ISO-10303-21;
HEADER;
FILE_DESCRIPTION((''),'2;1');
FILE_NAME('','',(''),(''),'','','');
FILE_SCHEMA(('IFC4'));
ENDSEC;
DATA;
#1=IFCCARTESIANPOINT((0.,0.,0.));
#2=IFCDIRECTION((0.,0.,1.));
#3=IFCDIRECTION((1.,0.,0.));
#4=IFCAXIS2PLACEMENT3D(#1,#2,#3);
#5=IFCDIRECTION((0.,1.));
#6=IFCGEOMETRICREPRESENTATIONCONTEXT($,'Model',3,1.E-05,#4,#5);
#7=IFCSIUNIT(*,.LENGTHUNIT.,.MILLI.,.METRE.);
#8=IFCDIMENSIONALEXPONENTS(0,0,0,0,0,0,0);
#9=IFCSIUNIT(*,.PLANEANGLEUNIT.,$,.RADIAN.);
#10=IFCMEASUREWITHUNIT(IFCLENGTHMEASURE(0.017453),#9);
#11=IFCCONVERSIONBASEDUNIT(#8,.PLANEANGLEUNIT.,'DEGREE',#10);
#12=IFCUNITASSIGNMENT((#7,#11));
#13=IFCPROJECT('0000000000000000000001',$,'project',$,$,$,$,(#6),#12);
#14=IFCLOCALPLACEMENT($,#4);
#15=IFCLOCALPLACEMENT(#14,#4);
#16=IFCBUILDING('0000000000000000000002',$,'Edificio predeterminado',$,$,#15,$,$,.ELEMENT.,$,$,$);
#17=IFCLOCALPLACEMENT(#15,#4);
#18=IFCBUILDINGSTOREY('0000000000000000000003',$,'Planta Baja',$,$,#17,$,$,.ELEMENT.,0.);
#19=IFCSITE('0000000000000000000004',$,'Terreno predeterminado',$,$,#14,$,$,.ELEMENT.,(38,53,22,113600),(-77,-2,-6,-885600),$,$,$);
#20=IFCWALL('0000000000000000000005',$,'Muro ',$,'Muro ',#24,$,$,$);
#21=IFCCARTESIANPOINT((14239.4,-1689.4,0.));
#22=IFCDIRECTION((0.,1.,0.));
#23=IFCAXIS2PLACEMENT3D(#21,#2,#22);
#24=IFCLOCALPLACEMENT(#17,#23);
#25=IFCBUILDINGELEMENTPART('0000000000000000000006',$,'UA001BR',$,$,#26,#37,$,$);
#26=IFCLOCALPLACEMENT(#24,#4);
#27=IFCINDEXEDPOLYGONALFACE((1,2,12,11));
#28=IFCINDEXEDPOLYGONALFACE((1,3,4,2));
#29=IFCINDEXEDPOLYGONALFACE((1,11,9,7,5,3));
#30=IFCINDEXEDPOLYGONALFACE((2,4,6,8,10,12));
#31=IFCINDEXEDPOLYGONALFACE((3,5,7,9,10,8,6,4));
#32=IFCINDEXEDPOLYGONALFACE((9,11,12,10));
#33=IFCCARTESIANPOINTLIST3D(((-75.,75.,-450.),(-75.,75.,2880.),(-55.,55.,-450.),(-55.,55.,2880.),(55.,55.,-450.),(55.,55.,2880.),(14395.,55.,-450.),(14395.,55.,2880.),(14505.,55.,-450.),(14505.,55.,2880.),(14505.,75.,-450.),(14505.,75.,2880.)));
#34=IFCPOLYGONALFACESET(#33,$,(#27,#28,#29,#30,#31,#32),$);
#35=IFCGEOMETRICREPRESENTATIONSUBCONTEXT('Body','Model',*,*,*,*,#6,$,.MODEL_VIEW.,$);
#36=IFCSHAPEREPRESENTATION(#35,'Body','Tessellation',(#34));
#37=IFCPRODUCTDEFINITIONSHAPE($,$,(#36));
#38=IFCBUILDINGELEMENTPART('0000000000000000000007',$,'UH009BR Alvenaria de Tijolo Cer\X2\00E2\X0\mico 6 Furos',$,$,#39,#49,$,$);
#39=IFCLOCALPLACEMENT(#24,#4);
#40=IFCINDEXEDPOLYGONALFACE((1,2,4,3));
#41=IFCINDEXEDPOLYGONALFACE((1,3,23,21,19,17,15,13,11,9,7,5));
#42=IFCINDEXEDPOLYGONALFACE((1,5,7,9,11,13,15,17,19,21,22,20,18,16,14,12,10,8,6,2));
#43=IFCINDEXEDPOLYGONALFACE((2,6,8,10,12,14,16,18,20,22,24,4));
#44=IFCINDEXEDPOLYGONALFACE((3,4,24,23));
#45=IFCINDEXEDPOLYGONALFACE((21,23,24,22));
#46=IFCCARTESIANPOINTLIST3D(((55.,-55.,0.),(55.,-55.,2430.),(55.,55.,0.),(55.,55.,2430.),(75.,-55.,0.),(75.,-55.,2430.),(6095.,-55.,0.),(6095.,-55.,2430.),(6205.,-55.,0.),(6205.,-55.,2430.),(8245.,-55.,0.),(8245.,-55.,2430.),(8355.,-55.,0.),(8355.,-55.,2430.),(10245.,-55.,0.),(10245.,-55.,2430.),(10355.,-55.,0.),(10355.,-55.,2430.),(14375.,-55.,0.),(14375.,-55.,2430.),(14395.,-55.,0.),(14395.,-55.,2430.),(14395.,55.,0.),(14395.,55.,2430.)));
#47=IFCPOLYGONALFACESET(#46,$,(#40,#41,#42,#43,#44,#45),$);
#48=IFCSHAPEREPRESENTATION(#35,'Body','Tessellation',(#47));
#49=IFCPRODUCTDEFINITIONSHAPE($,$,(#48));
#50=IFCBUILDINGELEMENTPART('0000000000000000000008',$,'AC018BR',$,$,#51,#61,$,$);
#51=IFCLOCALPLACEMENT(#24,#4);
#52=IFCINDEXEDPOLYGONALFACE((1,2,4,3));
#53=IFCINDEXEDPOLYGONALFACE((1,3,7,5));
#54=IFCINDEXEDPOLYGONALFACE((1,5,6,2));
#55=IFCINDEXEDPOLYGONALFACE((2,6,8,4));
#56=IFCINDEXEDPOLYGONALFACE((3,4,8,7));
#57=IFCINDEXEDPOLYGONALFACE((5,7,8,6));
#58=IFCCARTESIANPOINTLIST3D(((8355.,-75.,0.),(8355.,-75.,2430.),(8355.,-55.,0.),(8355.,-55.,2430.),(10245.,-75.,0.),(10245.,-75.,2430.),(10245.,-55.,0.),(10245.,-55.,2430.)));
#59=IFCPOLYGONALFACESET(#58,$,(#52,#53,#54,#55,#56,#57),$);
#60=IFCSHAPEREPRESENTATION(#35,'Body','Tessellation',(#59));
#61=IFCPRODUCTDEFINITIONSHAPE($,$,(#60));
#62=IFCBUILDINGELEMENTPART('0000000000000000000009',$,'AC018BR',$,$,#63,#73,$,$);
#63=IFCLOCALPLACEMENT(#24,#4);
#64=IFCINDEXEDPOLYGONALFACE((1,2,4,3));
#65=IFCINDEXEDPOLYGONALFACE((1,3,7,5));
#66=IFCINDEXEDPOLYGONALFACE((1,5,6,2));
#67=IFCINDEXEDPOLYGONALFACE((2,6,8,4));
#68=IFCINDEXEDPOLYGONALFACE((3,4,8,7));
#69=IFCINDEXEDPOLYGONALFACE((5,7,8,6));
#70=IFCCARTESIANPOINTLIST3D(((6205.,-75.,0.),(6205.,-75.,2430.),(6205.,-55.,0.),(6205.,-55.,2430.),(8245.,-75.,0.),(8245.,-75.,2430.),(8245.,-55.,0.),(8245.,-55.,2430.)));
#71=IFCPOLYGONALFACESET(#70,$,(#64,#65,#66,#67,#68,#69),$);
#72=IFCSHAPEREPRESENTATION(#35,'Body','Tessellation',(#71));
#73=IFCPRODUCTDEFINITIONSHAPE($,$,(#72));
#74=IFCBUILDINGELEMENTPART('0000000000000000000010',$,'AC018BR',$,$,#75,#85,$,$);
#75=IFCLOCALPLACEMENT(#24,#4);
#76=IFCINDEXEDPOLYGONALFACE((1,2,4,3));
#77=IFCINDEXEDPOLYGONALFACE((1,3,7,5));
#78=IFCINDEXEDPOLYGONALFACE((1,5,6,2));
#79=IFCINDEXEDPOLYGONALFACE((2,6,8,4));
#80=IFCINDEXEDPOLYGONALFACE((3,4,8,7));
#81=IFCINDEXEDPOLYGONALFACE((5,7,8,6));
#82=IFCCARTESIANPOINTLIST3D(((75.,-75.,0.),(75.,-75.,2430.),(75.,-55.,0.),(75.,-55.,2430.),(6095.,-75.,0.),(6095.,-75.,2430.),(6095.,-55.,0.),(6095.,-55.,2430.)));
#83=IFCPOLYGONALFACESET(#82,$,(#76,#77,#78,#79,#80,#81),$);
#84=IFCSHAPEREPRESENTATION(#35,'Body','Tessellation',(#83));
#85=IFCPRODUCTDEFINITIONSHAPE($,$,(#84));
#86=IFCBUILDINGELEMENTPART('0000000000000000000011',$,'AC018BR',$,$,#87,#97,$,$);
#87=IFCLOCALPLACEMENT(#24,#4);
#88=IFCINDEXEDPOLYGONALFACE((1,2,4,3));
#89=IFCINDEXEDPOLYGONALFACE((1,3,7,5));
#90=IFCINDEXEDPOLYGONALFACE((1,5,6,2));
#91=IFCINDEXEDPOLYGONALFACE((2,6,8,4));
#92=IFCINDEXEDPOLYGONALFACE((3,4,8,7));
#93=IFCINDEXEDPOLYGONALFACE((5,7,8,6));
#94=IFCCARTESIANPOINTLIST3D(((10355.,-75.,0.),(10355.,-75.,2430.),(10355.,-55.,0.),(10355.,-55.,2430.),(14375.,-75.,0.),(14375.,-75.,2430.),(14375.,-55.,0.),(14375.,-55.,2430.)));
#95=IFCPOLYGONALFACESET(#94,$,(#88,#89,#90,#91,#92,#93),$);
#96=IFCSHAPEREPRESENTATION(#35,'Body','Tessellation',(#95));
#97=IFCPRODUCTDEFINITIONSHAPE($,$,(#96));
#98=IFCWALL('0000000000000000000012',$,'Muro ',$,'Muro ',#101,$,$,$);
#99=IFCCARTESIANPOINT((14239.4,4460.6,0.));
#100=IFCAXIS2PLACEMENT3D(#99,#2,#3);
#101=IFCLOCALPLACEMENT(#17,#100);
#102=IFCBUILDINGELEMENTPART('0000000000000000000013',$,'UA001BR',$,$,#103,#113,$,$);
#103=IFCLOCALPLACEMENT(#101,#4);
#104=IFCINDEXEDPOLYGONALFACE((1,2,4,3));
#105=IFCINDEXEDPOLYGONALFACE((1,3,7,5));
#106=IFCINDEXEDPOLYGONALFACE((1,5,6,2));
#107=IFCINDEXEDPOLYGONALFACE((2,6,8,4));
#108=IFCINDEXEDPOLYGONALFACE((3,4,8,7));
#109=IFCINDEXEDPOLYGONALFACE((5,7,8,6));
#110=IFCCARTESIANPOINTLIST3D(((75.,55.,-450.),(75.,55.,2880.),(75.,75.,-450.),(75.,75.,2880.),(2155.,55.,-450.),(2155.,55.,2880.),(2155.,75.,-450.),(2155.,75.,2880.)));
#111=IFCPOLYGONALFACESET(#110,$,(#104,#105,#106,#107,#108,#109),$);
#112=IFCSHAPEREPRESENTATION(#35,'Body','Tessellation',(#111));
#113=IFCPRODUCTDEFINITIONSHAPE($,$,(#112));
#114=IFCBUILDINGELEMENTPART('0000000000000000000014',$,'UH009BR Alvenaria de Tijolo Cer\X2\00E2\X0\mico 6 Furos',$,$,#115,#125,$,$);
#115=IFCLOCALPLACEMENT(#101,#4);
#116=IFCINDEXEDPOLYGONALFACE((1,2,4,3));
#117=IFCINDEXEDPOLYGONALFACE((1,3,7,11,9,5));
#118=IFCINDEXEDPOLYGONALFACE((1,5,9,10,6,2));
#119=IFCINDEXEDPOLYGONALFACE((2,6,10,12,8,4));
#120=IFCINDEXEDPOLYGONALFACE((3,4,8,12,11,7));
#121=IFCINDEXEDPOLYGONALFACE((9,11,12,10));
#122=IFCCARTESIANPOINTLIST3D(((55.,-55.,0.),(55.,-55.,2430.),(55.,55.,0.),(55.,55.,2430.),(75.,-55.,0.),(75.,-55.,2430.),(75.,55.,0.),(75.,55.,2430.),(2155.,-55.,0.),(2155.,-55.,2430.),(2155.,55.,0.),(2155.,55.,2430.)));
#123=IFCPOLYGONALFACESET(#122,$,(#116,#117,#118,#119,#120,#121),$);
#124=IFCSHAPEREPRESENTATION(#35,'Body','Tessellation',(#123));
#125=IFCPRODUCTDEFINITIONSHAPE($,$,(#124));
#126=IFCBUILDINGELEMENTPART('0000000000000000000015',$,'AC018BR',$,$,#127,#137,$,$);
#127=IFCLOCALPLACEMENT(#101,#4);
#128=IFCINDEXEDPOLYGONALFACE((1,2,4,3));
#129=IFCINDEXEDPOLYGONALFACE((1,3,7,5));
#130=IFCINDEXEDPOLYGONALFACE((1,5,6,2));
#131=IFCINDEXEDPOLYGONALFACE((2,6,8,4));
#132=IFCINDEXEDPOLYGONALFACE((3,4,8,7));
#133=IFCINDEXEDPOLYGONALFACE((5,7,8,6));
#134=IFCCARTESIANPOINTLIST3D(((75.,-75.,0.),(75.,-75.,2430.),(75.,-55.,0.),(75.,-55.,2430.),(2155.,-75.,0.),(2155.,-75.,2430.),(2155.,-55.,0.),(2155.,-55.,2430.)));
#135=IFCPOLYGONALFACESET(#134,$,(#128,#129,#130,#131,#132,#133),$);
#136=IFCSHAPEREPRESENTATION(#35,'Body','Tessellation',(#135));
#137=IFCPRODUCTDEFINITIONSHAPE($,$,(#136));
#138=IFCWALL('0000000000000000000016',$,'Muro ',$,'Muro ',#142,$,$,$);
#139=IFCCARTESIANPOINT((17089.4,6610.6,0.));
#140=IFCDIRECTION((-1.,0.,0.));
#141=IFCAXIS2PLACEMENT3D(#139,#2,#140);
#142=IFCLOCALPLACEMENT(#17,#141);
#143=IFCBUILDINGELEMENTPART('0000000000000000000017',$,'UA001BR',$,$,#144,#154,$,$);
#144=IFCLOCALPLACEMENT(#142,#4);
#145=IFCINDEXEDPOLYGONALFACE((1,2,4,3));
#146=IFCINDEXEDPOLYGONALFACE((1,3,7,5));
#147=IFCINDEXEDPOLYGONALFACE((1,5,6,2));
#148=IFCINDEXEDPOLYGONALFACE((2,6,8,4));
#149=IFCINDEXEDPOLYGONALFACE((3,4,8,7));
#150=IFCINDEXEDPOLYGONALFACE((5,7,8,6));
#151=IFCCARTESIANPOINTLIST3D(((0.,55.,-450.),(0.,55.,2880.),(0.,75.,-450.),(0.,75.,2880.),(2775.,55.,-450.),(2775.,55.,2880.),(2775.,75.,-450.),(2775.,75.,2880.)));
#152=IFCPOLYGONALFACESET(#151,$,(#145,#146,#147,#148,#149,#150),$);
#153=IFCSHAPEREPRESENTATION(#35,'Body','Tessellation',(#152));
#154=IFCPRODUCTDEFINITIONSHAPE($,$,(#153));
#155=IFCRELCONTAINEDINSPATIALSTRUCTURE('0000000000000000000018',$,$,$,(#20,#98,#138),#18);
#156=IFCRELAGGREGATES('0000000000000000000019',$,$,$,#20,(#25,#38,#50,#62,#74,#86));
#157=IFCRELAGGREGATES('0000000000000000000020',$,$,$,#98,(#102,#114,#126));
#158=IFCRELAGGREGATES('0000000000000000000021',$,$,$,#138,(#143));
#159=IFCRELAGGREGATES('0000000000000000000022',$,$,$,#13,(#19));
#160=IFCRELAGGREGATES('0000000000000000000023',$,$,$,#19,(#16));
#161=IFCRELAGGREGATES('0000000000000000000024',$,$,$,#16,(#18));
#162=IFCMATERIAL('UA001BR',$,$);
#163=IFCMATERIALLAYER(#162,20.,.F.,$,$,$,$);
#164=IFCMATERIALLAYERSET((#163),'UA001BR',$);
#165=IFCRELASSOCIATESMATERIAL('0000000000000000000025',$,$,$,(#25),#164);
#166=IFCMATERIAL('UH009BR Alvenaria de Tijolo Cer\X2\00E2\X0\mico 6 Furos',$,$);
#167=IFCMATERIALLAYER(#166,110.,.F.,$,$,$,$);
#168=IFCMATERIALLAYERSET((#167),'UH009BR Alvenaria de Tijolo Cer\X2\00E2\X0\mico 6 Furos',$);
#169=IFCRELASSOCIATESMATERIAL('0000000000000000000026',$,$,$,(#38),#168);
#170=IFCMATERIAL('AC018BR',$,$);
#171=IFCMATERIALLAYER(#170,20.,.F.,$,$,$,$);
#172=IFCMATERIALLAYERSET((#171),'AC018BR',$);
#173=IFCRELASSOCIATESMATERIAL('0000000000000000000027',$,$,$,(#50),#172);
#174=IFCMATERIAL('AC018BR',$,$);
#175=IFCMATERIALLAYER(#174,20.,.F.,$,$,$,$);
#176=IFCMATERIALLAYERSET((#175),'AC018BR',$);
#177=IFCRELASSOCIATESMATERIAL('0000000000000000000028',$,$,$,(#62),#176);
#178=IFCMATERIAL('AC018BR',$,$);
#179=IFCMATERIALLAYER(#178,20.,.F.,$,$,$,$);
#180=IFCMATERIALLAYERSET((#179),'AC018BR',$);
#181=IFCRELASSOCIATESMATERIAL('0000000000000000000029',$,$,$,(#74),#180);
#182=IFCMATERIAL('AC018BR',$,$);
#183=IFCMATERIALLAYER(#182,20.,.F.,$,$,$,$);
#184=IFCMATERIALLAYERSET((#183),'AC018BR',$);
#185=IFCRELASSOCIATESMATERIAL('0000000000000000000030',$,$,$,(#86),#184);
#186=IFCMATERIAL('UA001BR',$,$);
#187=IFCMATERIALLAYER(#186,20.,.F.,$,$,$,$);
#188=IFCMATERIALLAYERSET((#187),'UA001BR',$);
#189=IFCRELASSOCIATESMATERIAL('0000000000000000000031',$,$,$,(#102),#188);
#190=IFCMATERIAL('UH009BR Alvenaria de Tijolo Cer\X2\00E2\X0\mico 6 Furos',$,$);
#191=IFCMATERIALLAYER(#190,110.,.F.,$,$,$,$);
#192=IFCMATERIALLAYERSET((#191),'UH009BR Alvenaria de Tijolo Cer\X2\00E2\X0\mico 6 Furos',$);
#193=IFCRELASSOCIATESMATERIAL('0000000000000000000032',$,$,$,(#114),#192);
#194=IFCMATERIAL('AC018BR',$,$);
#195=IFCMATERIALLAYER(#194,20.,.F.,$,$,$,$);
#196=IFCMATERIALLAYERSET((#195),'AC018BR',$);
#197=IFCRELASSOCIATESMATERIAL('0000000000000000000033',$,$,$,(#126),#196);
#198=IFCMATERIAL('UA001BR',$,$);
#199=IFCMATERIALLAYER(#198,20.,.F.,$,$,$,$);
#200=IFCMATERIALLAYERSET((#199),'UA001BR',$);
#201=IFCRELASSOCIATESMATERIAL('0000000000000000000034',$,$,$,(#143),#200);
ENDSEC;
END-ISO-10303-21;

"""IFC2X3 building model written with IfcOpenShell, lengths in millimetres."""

from ifc_helpers import new_model, entity, si_unit, converted_unit, direction, frame, origin_with_axes, place, context, subcontext, project, spatial, polyline, outline, extrude, material, layer, layer_set, layer_usage, element, aggregate, save


model = new_model("IFC2X3")

# Units and contexts
model_context = context("Model", 3, precision=1e-05, world=origin_with_axes(), true_north=direction((0.0, 1.0)))
body_context = subcontext(model_context, "Body", "Model", "MODEL_VIEW")
ifc_project = project(units=[si_unit("LENGTHUNIT", "METRE", prefix="MILLI"), converted_unit("PLANEANGLEUNIT", "DEGREE", entity("IfcLengthMeasure", 0.017453), si_unit("PLANEANGLEUNIT", "RADIAN"), dimensions=[0, 0, 0, 0, 0, 0, 0])], contexts=[model_context])

# Site, building, storey
site_placement = place(None, origin_with_axes())
site = spatial("IfcSite", under=ifc_project, at=site_placement, Name="Terreno predeterminado", CompositionType="ELEMENT", RefLatitude=(38, 53, 22, 113600), RefLongitude=(-77, -2, -6, -885600))
building_placement = place(site_placement, origin_with_axes())
building = spatial("IfcBuilding", under=site, at=building_placement, Name="Edificio predeterminado", CompositionType="ELEMENT")
storey_placement = place(building_placement, origin_with_axes())
storey = spatial("IfcBuildingStorey", under=building, at=storey_placement, Name="Planta Baja", CompositionType="ELEMENT", Elevation=0.0)

# Walls, building element parts
wall_1_placement = place(storey_placement, frame((14239.4, -1689.4, 0.0), z_axis=(0.0, 0.0, 1.0), x_axis=(0.0, 1.0, 0.0)))
wall_1 = element("IfcWall", 1, at=wall_1_placement, inside=storey, Name="Muro ", ObjectType="Muro ")
ifc_material_1 = material(Name="UA001BR")
ifc_layer_1 = layer(ifc_material_1, 20.0, ventilated=False)
ifc_layer_set_1 = layer_set([ifc_layer_1], Name="UA001BR")
ifc_layer_usage_1 = layer_usage(ifc_layer_set_1, "AXIS2", "NEGATIVE", -75.0)
building_element_part_1_placement = place(wall_1_placement, origin_with_axes())
building_element_part_1 = element("IfcBuildingElementPart", 2, at=building_element_part_1_placement, material=ifc_layer_usage_1, Name="UA001BR", context=body_context, shape_type="SweptSolid", body=[
    extrude(outline(polyline([(14505.0, 75.0), (14505.0, 55.0), (14395.0, 55.0), (55.0, 55.0), (-55.0, 55.0), (-75.0, 75.0), (14505.0, 75.0)])), frame((0.0, 0.0, -450.0), z_axis=(0.0, 0.0, 1.0), x_axis=(1.0, 0.0, 0.0)), (0.0, 0.0, 1.0), 3330.0),
])
ifc_material_2 = material(Name="UH009BR Alvenaria de Tijolo Cerâmico 6 Furos")
ifc_layer_2 = layer(ifc_material_2, 110.0, ventilated=False)
ifc_layer_set_2 = layer_set([ifc_layer_2], Name="UH009BR Alvenaria de Tijolo Cerâmico 6 Furos")
ifc_layer_usage_2 = layer_usage(ifc_layer_set_2, "AXIS2", "NEGATIVE", -55.0)
building_element_part_2_placement = place(wall_1_placement, origin_with_axes())
building_element_part_2 = element("IfcBuildingElementPart", 3, at=building_element_part_2_placement, material=ifc_layer_usage_2, Name="UH009BR Alvenaria de Tijolo Cerâmico 6 Furos", context=body_context, shape_type="SweptSolid", body=[
    extrude(outline(polyline([(14395.0, 55.0), (14395.0, -55.0), (14375.0, -55.0), (10355.0, -55.0), (10245.0, -55.0), (8355.0, -55.0), (8245.0, -55.0), (6205.0, -55.0), (6095.0, -55.0), (75.0, -55.0), (55.0, -55.0), (55.0, 55.0), (14395.0, 55.0)])), origin_with_axes(), (0.0, 0.0, 1.0), 2430.0),
])
ifc_material_3 = material(Name="AC018BR")
ifc_layer_3 = layer(ifc_material_3, 20.0, ventilated=False)
ifc_layer_set_3 = layer_set([ifc_layer_3], Name="AC018BR")
ifc_layer_usage_3 = layer_usage(ifc_layer_set_3, "AXIS2", "NEGATIVE", 55.0)
building_element_part_3_placement = place(wall_1_placement, origin_with_axes())
building_element_part_3 = element("IfcBuildingElementPart", 4, at=building_element_part_3_placement, material=ifc_layer_usage_3, Name="AC018BR", context=body_context, shape_type="SweptSolid", body=[
    extrude(outline(polyline([(8355.0, -55.0), (10245.0, -55.0), (10245.0, -75.0), (8355.0, -75.0), (8355.0, -55.0)])), origin_with_axes(), (0.0, 0.0, 1.0), 2430.0),
])
ifc_material_4 = material(Name="AC018BR")
ifc_layer_4 = layer(ifc_material_4, 20.0, ventilated=False)
ifc_layer_set_4 = layer_set([ifc_layer_4], Name="AC018BR")
ifc_layer_usage_4 = layer_usage(ifc_layer_set_4, "AXIS2", "NEGATIVE", 55.0)
building_element_part_4_placement = place(wall_1_placement, origin_with_axes())
building_element_part_4 = element("IfcBuildingElementPart", 5, at=building_element_part_4_placement, material=ifc_layer_usage_4, Name="AC018BR", context=body_context, shape_type="SweptSolid", body=[
    extrude(outline(polyline([(8245.0, -55.0), (8245.0, -75.0), (6205.0, -75.0), (6205.0, -55.0), (8245.0, -55.0)])), origin_with_axes(), (0.0, 0.0, 1.0), 2430.0),
])
ifc_material_5 = material(Name="AC018BR")
ifc_layer_5 = layer(ifc_material_5, 20.0, ventilated=False)
ifc_layer_set_5 = layer_set([ifc_layer_5], Name="AC018BR")
ifc_layer_usage_5 = layer_usage(ifc_layer_set_5, "AXIS2", "NEGATIVE", 55.0)
building_element_part_5_placement = place(wall_1_placement, origin_with_axes())
building_element_part_5 = element("IfcBuildingElementPart", 6, at=building_element_part_5_placement, material=ifc_layer_usage_5, Name="AC018BR", context=body_context, shape_type="SweptSolid", body=[
    extrude(outline(polyline([(6095.0, -55.0), (6095.0, -75.0), (75.0, -75.0), (75.0, -55.0), (6095.0, -55.0)])), origin_with_axes(), (0.0, 0.0, 1.0), 2430.0),
])
ifc_material_6 = material(Name="AC018BR")
ifc_layer_6 = layer(ifc_material_6, 20.0, ventilated=False)
ifc_layer_set_6 = layer_set([ifc_layer_6], Name="AC018BR")
ifc_layer_usage_6 = layer_usage(ifc_layer_set_6, "AXIS2", "NEGATIVE", 55.0)
building_element_part_6_placement = place(wall_1_placement, origin_with_axes())
building_element_part_6 = element("IfcBuildingElementPart", 7, at=building_element_part_6_placement, material=ifc_layer_usage_6, Name="AC018BR", context=body_context, shape_type="SweptSolid", body=[
    extrude(outline(polyline([(14375.0, -55.0), (14375.0, -75.0), (10355.0, -75.0), (10355.0, -55.0), (14375.0, -55.0)])), origin_with_axes(), (0.0, 0.0, 1.0), 2430.0),
])
aggregate(wall_1, [building_element_part_1, building_element_part_2, building_element_part_3, building_element_part_4, building_element_part_5, building_element_part_6])
wall_2_placement = place(storey_placement, frame((14239.4, 4460.6, 0.0), z_axis=(0.0, 0.0, 1.0), x_axis=(1.0, 0.0, 0.0)))
wall_2 = element("IfcWall", 8, at=wall_2_placement, inside=storey, Name="Muro ", ObjectType="Muro ")
ifc_material_7 = material(Name="UA001BR")
ifc_layer_7 = layer(ifc_material_7, 20.0, ventilated=False)
ifc_layer_set_7 = layer_set([ifc_layer_7], Name="UA001BR")
ifc_layer_usage_7 = layer_usage(ifc_layer_set_7, "AXIS2", "NEGATIVE", -75.0)
building_element_part_7_placement = place(wall_2_placement, origin_with_axes())
building_element_part_7 = element("IfcBuildingElementPart", 9, at=building_element_part_7_placement, material=ifc_layer_usage_7, Name="UA001BR", context=body_context, shape_type="SweptSolid", body=[
    extrude(outline(polyline([(2155.0, 75.0), (2155.0, 55.0), (75.0, 55.0), (75.0, 75.0), (2155.0, 75.0)])), frame((0.0, 0.0, -450.0), z_axis=(0.0, 0.0, 1.0), x_axis=(1.0, 0.0, 0.0)), (0.0, 0.0, 1.0), 3330.0),
])
ifc_material_8 = material(Name="UH009BR Alvenaria de Tijolo Cerâmico 6 Furos")
ifc_layer_8 = layer(ifc_material_8, 110.0, ventilated=False)
ifc_layer_set_8 = layer_set([ifc_layer_8], Name="UH009BR Alvenaria de Tijolo Cerâmico 6 Furos")
ifc_layer_usage_8 = layer_usage(ifc_layer_set_8, "AXIS2", "NEGATIVE", -55.0)
building_element_part_8_placement = place(wall_2_placement, origin_with_axes())
building_element_part_8 = element("IfcBuildingElementPart", 10, at=building_element_part_8_placement, material=ifc_layer_usage_8, Name="UH009BR Alvenaria de Tijolo Cerâmico 6 Furos", context=body_context, shape_type="SweptSolid", body=[
    extrude(outline(polyline([(2155.0, 55.0), (2155.0, -55.0), (75.0, -55.0), (55.0, -55.0), (55.0, 55.0), (75.0, 55.0), (2155.0, 55.0)])), origin_with_axes(), (0.0, 0.0, 1.0), 2430.0),
])
ifc_material_9 = material(Name="AC018BR")
ifc_layer_9 = layer(ifc_material_9, 20.0, ventilated=False)
ifc_layer_set_9 = layer_set([ifc_layer_9], Name="AC018BR")
ifc_layer_usage_9 = layer_usage(ifc_layer_set_9, "AXIS2", "NEGATIVE", 55.0)
building_element_part_9_placement = place(wall_2_placement, origin_with_axes())
building_element_part_9 = element("IfcBuildingElementPart", 11, at=building_element_part_9_placement, material=ifc_layer_usage_9, Name="AC018BR", context=body_context, shape_type="SweptSolid", body=[
    extrude(outline(polyline([(2155.0, -55.0), (2155.0, -75.0), (75.0, -75.0), (75.0, -55.0), (2155.0, -55.0)])), origin_with_axes(), (0.0, 0.0, 1.0), 2430.0),
])
aggregate(wall_2, [building_element_part_7, building_element_part_8, building_element_part_9])

# Wall, building element part
wall_3_placement = place(storey_placement, frame((17089.4, 6610.6, 0.0), z_axis=(0.0, 0.0, 1.0), x_axis=(-1.0, 0.0, 0.0)))
wall_3 = element("IfcWall", 12, at=wall_3_placement, inside=storey, Name="Muro ", ObjectType="Muro ")
ifc_material_10 = material(Name="UA001BR")
ifc_layer_10 = layer(ifc_material_10, 20.0, ventilated=False)
ifc_layer_set_10 = layer_set([ifc_layer_10], Name="UA001BR")
ifc_layer_usage_10 = layer_usage(ifc_layer_set_10, "AXIS2", "NEGATIVE", -75.0)
building_element_part_10_placement = place(wall_3_placement, origin_with_axes())
building_element_part_10 = element("IfcBuildingElementPart", 13, at=building_element_part_10_placement, material=ifc_layer_usage_10, Name="UA001BR", context=body_context, shape_type="SweptSolid", body=[
    extrude(outline(polyline([(0.0, 75.0), (2775.0, 75.0), (2775.0, 55.0), (0.0, 55.0), (0.0, 75.0)])), frame((0.0, 0.0, -450.0), z_axis=(0.0, 0.0, 1.0), x_axis=(1.0, 0.0, 0.0)), (0.0, 0.0, 1.0), 3330.0),
])
aggregate(wall_3, [building_element_part_10])

save(model, "model.ifc")
